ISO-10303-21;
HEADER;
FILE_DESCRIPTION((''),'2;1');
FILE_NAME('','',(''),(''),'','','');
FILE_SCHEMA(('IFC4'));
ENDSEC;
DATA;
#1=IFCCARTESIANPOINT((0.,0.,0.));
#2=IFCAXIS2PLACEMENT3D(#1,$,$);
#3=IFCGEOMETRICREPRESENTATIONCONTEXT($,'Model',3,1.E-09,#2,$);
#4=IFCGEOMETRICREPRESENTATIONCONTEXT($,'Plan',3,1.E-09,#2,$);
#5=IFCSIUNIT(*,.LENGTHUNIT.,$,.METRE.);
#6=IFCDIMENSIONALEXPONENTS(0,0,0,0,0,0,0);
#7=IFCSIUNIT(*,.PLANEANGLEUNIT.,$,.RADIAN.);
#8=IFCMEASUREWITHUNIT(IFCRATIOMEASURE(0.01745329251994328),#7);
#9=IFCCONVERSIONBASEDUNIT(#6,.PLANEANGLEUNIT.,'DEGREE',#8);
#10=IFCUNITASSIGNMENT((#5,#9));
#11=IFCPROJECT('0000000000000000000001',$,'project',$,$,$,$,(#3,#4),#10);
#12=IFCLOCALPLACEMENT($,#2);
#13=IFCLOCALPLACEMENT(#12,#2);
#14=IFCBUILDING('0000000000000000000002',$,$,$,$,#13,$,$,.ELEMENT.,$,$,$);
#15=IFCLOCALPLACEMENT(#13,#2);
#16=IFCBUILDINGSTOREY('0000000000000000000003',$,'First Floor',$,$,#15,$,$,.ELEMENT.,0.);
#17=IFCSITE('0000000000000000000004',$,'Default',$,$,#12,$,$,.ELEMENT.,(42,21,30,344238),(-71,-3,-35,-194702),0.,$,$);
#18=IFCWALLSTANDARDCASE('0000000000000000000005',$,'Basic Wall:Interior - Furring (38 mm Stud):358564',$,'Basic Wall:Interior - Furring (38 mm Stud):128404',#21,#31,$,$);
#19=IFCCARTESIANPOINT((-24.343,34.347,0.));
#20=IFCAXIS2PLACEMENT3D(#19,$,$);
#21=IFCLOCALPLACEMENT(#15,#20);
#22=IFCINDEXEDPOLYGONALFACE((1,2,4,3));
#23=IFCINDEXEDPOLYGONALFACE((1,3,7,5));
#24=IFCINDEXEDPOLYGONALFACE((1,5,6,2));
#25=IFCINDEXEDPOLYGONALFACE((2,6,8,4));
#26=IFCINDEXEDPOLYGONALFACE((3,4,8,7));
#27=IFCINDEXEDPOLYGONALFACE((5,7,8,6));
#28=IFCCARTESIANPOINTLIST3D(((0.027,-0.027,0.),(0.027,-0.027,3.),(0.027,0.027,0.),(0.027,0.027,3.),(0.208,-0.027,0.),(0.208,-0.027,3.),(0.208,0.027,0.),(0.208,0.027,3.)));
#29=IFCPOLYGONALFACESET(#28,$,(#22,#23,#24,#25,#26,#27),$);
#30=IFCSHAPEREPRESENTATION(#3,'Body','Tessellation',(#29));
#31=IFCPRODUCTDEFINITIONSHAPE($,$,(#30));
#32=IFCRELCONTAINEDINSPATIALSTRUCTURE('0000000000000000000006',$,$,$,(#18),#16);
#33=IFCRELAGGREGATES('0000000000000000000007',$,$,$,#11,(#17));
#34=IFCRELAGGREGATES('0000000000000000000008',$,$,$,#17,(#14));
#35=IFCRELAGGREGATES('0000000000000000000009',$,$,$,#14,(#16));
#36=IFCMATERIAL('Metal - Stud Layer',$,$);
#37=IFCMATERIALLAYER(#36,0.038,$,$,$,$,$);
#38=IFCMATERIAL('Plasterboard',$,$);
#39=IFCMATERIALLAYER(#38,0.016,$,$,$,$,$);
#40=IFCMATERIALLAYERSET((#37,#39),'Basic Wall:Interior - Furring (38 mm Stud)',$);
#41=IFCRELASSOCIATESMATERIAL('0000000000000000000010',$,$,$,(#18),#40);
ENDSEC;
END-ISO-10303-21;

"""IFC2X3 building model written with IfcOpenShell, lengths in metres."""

from ifc_helpers import new_model, entity, si_unit, converted_unit, frame, frame_2d, origin, place, context, project, spatial, rectangle, extrude, material, layer, layer_set, layer_usage, element, save


model = new_model("IFC2X3")

# Units and contexts
model_context = context("Model", 3, precision=1e-09, world=origin())
plan_context = context("Plan", 3, precision=1e-09, world=origin())
ifc_project = project(units=[si_unit("LENGTHUNIT", "METRE"), converted_unit("PLANEANGLEUNIT", "DEGREE", entity("IfcRatioMeasure", 0.01745329251994328), si_unit("PLANEANGLEUNIT", "RADIAN"), dimensions=[0, 0, 0, 0, 0, 0, 0])], contexts=[model_context, plan_context])

# Site, building, storey
site_placement = place(None, origin())
site = spatial("IfcSite", under=ifc_project, at=site_placement, Name="Default", CompositionType="ELEMENT", RefLatitude=(42, 21, 30, 344238), RefLongitude=(-71, -3, -35, -194702), RefElevation=0.0)
building_placement = place(site_placement, origin())
building = spatial("IfcBuilding", under=site, at=building_placement, CompositionType="ELEMENT")
storey_placement = place(building_placement, origin())
storey = spatial("IfcBuildingStorey", under=building, at=storey_placement, Name="First Floor", CompositionType="ELEMENT", Elevation=0.0)

# Shared definitions
ifc_material_1 = material(Name="Plasterboard")
ifc_material_2 = material(Name="Metal - Stud Layer")

# Shared definitions
ifc_layer_1 = layer(ifc_material_2, 0.038)
ifc_layer_2 = layer(ifc_material_1, 0.016)
ifc_layer_set_1 = layer_set([ifc_layer_1, ifc_layer_2], Name="Basic Wall:Interior - Furring (38 mm Stud)")
ifc_layer_usage_1 = layer_usage(ifc_layer_set_1, "AXIS2", "NEGATIVE", 0.027)

# Wall
wall_1_placement = place(storey_placement, frame((-24.343, 34.347, 0.0)))
element("IfcWallStandardCase", 1, at=wall_1_placement, inside=storey, material=ifc_layer_usage_1, Name="Basic Wall:Interior - Furring (38 mm Stud):358564", ObjectType="Basic Wall:Interior - Furring (38 mm Stud):128404", context=model_context, shape_type="SweptSolid", body=[
    extrude(rectangle(XDim=0.181, YDim=0.054, at=frame_2d((0.1175, 0.0), x_axis=(-1.0, 0.0))), origin(), (0.0, 0.0, 1.0), 3.0),
])

save(model, "model.ifc")
